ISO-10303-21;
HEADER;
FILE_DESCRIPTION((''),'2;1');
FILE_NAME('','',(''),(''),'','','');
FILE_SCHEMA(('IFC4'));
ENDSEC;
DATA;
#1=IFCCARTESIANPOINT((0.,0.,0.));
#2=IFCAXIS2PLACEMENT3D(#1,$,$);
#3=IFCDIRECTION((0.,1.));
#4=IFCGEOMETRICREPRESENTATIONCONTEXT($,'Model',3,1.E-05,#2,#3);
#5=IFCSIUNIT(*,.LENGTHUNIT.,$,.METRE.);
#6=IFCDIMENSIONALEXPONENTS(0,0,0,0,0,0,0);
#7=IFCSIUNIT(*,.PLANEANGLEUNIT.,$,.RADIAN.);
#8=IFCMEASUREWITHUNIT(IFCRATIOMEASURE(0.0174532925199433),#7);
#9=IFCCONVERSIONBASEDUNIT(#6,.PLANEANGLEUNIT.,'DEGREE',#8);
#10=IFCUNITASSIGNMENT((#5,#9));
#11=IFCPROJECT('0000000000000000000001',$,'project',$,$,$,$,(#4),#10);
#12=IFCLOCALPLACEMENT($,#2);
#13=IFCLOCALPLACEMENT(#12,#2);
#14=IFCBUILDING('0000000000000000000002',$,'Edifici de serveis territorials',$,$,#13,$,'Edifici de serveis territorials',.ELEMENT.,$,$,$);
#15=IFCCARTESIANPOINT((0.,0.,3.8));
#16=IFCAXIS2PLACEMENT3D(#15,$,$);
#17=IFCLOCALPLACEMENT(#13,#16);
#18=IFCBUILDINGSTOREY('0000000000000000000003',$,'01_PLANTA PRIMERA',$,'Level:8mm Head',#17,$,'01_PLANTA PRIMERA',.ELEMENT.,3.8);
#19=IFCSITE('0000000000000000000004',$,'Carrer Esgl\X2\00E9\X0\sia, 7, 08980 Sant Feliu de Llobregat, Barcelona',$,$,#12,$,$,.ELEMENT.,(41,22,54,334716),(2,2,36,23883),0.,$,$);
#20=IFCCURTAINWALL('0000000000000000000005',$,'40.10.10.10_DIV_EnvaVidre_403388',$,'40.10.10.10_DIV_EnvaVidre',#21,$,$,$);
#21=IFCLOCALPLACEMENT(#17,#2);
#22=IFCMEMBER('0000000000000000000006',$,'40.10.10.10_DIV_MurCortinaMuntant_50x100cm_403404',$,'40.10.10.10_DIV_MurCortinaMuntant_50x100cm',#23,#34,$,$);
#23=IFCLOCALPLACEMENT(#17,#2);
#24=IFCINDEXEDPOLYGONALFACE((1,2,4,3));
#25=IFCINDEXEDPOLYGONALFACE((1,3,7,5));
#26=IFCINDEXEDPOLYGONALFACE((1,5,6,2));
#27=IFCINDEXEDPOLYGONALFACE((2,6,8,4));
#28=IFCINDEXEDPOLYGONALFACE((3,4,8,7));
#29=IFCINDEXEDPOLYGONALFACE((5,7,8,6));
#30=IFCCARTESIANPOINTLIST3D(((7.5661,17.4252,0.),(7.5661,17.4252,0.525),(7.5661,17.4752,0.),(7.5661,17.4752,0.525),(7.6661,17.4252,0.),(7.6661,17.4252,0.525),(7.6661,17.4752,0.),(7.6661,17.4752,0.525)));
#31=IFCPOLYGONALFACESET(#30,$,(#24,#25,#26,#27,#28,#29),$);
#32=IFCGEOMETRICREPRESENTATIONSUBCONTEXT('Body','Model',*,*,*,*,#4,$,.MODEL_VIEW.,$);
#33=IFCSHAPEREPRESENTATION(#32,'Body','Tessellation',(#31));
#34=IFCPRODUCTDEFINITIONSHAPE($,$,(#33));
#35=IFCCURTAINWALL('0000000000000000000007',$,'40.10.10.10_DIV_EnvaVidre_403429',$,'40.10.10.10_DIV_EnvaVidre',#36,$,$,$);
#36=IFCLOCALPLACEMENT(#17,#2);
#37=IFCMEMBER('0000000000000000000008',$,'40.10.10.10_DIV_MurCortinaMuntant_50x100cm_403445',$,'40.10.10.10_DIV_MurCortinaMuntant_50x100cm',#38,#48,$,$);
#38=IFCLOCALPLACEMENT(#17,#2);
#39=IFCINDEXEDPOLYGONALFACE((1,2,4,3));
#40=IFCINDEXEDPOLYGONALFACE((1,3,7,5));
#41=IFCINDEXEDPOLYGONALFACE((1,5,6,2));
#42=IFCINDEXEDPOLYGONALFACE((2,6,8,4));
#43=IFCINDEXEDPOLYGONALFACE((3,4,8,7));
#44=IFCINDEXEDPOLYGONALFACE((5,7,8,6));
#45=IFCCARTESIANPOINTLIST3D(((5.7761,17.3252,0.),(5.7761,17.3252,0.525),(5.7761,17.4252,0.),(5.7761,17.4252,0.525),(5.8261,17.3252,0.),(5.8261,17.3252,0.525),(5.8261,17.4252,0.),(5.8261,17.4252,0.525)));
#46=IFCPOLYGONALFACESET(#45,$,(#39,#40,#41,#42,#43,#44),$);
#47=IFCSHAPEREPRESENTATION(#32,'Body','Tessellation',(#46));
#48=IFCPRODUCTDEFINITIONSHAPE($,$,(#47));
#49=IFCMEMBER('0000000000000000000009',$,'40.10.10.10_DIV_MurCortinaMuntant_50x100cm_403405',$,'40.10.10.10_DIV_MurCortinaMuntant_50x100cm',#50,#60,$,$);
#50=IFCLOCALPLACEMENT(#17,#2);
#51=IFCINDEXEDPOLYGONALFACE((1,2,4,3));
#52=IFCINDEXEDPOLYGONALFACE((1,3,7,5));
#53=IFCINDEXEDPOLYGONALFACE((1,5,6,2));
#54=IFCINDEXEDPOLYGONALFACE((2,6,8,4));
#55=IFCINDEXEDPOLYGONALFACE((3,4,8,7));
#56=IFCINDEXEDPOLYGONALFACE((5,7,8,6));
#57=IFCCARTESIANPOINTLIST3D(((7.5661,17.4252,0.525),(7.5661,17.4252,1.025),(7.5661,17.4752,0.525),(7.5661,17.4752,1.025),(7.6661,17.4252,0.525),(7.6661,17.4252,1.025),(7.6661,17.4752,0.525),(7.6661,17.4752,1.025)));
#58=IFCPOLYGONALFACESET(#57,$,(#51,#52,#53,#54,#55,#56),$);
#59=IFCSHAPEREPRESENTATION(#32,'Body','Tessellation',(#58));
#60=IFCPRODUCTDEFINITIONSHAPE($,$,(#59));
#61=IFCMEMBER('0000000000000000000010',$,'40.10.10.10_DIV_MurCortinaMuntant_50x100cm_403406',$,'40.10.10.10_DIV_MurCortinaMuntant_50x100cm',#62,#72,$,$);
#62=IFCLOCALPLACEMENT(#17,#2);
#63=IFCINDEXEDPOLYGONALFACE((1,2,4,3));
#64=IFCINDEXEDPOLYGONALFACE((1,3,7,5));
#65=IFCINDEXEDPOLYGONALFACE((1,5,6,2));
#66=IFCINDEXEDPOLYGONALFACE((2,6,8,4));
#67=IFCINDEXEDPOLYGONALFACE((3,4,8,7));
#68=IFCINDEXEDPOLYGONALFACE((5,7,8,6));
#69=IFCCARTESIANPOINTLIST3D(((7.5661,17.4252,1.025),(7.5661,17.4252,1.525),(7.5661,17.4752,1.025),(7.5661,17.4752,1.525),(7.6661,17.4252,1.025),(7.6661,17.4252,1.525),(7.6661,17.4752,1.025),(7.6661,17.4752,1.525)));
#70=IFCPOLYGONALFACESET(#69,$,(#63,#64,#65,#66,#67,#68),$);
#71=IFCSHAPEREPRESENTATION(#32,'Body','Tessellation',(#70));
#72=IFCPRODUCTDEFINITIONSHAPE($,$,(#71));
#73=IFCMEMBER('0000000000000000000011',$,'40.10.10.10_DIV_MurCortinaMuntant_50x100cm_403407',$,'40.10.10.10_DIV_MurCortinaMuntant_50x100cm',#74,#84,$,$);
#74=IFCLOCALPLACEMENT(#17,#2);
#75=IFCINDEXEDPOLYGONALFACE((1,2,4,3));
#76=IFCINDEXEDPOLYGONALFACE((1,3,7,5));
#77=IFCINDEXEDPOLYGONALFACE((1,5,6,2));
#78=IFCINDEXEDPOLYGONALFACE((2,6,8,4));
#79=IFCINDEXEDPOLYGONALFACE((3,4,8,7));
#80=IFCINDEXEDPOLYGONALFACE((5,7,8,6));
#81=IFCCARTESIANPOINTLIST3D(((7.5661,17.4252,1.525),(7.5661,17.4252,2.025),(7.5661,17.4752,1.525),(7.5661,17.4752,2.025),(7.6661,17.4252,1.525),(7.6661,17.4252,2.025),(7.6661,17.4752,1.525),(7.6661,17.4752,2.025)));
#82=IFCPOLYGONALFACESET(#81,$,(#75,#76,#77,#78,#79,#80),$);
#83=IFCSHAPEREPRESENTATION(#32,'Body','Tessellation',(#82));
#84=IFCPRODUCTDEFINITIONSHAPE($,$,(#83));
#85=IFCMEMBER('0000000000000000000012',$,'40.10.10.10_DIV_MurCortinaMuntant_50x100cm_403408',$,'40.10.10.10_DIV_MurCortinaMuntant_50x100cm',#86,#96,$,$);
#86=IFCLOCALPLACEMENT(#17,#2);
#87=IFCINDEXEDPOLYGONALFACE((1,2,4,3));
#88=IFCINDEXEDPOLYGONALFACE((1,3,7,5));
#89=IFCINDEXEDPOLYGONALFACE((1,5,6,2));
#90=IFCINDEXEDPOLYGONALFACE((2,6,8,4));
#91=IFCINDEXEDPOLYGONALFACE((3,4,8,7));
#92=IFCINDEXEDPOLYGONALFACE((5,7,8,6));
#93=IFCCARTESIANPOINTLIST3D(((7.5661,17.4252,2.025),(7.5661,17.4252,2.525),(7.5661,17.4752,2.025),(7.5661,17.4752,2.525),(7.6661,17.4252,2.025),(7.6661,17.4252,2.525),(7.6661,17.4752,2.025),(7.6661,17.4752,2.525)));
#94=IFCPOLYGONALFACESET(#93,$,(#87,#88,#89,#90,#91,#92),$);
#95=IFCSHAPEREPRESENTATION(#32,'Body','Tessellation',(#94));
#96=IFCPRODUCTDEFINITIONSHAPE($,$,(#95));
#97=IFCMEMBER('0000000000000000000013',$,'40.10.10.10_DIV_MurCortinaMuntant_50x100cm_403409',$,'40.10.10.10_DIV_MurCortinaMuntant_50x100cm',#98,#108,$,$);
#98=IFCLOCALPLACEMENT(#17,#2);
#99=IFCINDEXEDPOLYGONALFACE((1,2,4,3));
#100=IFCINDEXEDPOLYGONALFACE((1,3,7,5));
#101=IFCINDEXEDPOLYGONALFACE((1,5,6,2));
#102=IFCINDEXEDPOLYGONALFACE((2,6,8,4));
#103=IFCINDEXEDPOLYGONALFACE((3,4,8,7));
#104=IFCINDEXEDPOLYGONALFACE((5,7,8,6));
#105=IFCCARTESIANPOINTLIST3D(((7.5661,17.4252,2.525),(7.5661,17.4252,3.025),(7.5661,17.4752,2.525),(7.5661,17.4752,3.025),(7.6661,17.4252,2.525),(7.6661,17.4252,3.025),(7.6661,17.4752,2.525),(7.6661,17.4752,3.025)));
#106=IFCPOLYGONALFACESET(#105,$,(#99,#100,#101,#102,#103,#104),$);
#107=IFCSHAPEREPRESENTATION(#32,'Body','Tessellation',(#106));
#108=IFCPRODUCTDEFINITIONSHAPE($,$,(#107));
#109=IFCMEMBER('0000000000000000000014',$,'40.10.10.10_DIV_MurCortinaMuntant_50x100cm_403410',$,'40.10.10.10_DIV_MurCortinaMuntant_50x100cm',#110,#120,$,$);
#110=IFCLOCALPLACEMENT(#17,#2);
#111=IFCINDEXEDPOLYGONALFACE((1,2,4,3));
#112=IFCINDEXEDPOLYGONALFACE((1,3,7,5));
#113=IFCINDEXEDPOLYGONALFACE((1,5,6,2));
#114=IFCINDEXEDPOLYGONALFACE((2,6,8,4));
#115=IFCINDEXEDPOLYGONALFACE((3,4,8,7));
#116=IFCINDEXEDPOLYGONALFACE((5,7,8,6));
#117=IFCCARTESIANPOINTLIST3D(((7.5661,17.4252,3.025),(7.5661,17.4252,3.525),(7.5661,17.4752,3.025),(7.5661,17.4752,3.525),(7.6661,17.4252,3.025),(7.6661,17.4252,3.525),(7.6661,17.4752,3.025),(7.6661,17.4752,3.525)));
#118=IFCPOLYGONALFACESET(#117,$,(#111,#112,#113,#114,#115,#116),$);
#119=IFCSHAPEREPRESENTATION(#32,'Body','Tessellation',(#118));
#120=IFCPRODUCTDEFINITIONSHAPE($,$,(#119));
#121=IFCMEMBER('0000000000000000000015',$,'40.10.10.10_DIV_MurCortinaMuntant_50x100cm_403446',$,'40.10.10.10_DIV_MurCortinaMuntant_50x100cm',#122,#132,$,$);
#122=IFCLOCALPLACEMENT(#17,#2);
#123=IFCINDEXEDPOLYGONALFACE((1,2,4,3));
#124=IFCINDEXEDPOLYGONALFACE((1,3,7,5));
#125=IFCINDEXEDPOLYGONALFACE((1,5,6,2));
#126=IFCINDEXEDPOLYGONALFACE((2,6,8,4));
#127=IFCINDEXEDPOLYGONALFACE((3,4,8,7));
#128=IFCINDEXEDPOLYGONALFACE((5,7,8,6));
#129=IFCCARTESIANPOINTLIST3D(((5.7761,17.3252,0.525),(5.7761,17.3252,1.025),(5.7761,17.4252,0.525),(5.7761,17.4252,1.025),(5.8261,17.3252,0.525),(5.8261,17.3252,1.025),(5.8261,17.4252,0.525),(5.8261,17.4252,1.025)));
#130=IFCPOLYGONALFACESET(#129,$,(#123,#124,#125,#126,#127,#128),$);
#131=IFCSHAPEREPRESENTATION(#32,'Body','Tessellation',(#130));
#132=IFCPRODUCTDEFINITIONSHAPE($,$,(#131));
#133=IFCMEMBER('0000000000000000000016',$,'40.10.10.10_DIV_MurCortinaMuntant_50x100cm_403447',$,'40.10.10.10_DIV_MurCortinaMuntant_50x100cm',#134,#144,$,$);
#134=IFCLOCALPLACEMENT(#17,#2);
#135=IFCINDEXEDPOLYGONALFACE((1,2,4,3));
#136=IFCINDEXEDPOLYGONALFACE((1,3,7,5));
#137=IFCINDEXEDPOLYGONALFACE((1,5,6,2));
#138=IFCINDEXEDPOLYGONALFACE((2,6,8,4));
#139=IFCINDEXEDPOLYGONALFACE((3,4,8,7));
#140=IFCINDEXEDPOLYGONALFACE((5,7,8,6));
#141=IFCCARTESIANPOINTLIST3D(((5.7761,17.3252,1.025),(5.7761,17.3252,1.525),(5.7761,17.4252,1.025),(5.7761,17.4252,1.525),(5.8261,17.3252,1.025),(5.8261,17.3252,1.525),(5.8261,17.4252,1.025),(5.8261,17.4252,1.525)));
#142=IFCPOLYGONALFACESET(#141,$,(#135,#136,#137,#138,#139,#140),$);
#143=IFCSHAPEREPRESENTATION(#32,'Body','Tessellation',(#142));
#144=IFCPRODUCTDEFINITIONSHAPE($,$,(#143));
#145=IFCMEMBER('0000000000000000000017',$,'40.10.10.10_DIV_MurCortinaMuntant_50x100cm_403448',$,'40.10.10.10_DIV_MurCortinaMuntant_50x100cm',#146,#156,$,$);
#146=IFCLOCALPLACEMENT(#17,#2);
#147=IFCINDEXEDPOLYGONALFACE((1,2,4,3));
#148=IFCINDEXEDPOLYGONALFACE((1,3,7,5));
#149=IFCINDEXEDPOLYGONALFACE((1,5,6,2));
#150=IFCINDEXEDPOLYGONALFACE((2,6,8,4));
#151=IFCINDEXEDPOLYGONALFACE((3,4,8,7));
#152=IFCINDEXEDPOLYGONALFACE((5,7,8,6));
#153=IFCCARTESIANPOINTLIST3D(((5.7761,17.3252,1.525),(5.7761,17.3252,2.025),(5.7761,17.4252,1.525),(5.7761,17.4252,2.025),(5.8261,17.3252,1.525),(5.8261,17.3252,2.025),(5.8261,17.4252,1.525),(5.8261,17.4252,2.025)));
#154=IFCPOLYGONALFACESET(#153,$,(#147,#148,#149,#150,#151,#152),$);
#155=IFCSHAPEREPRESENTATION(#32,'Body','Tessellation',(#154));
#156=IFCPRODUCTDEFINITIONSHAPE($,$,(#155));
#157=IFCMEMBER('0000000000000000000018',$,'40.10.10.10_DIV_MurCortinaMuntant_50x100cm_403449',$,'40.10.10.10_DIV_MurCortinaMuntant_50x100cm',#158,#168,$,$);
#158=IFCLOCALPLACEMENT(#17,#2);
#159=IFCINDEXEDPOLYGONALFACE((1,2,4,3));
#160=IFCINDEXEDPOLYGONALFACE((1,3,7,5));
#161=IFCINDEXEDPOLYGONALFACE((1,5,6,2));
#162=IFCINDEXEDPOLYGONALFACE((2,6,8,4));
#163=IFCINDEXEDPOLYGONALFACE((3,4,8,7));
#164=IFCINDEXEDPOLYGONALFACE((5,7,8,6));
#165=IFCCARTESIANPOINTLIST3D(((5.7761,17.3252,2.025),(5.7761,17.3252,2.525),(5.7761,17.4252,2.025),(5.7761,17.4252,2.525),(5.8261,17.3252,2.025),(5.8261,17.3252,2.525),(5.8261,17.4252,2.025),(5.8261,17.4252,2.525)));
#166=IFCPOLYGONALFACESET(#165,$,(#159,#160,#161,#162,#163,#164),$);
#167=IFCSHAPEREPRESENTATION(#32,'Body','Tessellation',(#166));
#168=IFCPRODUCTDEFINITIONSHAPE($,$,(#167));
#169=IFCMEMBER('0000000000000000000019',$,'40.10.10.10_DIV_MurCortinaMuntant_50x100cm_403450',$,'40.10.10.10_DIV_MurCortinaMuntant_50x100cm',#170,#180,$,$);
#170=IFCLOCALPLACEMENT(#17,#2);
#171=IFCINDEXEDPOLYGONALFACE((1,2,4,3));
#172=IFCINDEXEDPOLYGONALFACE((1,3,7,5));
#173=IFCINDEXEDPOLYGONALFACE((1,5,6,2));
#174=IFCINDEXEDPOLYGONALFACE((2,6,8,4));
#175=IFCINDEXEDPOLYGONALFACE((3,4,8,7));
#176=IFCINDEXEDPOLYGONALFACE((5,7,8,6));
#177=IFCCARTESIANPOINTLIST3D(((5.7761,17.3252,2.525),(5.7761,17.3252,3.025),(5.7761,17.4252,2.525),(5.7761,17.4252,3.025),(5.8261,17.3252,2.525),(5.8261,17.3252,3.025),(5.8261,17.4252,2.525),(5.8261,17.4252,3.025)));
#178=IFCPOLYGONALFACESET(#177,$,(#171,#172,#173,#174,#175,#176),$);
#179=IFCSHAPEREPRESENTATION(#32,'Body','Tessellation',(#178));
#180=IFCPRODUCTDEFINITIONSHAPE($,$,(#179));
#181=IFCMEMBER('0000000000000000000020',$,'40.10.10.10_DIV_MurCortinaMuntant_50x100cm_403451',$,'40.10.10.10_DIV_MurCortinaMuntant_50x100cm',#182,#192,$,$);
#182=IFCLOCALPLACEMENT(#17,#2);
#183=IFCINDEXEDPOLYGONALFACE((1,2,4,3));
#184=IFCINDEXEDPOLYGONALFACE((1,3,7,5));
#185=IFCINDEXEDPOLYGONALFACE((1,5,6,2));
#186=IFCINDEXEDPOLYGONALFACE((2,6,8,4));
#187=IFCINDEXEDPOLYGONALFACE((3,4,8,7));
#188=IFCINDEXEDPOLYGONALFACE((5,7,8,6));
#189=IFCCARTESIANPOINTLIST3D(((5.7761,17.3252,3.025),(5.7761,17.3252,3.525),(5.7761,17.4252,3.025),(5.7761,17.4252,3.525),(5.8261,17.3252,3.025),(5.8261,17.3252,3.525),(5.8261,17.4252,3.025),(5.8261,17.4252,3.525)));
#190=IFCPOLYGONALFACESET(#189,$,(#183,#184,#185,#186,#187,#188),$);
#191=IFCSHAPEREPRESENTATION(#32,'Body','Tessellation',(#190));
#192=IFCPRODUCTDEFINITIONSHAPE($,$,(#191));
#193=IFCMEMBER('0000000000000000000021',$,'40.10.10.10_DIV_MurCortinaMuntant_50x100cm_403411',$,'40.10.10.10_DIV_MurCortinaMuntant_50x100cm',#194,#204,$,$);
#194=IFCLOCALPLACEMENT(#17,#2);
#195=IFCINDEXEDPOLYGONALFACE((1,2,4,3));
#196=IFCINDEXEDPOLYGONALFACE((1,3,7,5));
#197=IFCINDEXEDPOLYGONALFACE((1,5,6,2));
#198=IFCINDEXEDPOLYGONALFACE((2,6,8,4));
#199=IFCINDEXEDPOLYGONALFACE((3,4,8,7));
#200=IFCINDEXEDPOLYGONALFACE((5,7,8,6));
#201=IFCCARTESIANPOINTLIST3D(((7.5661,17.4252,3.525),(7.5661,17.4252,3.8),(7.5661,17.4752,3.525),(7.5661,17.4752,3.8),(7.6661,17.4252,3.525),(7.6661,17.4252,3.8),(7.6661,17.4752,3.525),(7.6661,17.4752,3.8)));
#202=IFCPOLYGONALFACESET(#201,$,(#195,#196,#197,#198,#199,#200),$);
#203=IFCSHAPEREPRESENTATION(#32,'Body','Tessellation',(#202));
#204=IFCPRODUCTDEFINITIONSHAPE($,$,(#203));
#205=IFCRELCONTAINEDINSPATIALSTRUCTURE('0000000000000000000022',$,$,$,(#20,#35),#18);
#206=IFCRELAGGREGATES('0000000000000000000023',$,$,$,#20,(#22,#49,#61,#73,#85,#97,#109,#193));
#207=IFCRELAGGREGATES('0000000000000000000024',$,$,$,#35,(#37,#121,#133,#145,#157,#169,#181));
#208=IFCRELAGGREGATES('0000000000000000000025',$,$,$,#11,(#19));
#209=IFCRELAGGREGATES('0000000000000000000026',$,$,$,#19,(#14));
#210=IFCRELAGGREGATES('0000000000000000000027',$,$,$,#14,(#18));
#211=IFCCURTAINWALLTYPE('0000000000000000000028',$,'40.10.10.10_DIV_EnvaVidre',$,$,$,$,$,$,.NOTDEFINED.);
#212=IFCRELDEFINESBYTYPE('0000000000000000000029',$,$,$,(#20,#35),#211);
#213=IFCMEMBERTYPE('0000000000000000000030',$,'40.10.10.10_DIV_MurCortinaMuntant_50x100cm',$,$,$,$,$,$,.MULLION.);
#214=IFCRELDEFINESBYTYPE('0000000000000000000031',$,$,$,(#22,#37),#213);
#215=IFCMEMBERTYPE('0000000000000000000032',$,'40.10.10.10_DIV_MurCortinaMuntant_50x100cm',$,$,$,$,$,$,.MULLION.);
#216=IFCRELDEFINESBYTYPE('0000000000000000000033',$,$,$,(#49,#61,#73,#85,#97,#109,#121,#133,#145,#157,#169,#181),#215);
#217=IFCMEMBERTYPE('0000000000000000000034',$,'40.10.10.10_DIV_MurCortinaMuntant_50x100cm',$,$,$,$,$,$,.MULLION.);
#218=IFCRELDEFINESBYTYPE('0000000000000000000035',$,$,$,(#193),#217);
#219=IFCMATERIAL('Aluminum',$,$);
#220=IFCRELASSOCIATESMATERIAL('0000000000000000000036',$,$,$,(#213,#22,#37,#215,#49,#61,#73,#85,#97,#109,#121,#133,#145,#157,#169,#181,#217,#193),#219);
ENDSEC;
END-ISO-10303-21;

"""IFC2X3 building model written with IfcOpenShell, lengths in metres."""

from ifc_helpers import new_model, entity, si_unit, converted_unit, direction, frame, origin, origin_2d_with_axis, place, context, subcontext, project, spatial, rectangle, extrude, source, transform, mapped, material, type_object, type_shapes, element, aggregate, save


model = new_model("IFC2X3")

# Units and contexts
model_context = context("Model", 3, precision=1e-05, world=origin(), true_north=direction((0.0, 1.0)))
body_context = subcontext(model_context, "Body", "Model", "MODEL_VIEW")
ifc_project = project(units=[si_unit("LENGTHUNIT", "METRE"), converted_unit("PLANEANGLEUNIT", "DEGREE", entity("IfcRatioMeasure", 0.0174532925199433), si_unit("PLANEANGLEUNIT", "RADIAN"), dimensions=[0, 0, 0, 0, 0, 0, 0])], contexts=[model_context])

# Site, building, storey
site_placement = place(None, origin())
site = spatial("IfcSite", under=ifc_project, at=site_placement, Name="Carrer Església, 7, 08980 Sant Feliu de Llobregat, Barcelona", CompositionType="ELEMENT", RefLatitude=(41, 22, 54, 334716), RefLongitude=(2, 2, 36, 23883), RefElevation=0.0)
building_placement = place(site_placement, origin())
building = spatial("IfcBuilding", under=site, at=building_placement, Name="Edifici de serveis territorials", LongName="Edifici de serveis territorials", CompositionType="ELEMENT")
storey_placement = place(building_placement, frame((0.0, 0.0, 3.8)))
storey = spatial("IfcBuildingStorey", under=building, at=storey_placement, Name="01_PLANTA PRIMERA", ObjectType="Level:8mm Head", LongName="01_PLANTA PRIMERA", CompositionType="ELEMENT", Elevation=3.8)

# Curtain walls, members
curtain_wall_type = type_object("IfcCurtainWallType", Name="40.10.10.10_DIV_EnvaVidre", PredefinedType="NOTDEFINED")
curtain_wall_1_placement = place(storey_placement, frame((0.0, 0.0, -3.8)))
curtain_wall_1 = element("IfcCurtainWall", 1, at=curtain_wall_1_placement, inside=storey, type_object=curtain_wall_type, Name="40.10.10.10_DIV_EnvaVidre_403388", ObjectType="40.10.10.10_DIV_EnvaVidre")
ifc_material_1 = material(Name="Aluminum")
member_type_1 = type_object("IfcMemberType", Name="40.10.10.10_DIV_MurCortinaMuntant_50x100cm", PredefinedType="MULLION", material=ifc_material_1)
shared_shape_1 = source(origin(), body_context, "Body", "SweptSolid", [
    extrude(rectangle(XDim=0.1, YDim=0.05, at=origin_2d_with_axis()), frame((-0.025, 0.0, -0.525), z_axis=(0.0, 0.0, 1.0), x_axis=(0.0, -1.0, 0.0)), (0.0, 0.0, 1.0), 0.525),
])
type_shapes(member_type_1, [shared_shape_1])
member_1_placement = place(storey_placement, frame((7.6161, 17.4252, 0.0), z_axis=(0.0, 0.0, -1.0), x_axis=(0.0, -1.0, 0.0)))
member_1 = element("IfcMember", 2, at=member_1_placement, type_object=member_type_1, material=ifc_material_1, Name="40.10.10.10_DIV_MurCortinaMuntant_50x100cm_403404", ObjectType="40.10.10.10_DIV_MurCortinaMuntant_50x100cm", context=body_context, shape_type="MappedRepresentation", body=[
    mapped(shared_shape_1, transform((0.0, 0.0, 0.0), scale=1.0)),
])
curtain_wall_2_placement = place(storey_placement, frame((0.0, 0.0, -3.8)))
curtain_wall_2 = element("IfcCurtainWall", 3, at=curtain_wall_2_placement, inside=storey, type_object=curtain_wall_type, Name="40.10.10.10_DIV_EnvaVidre_403429", ObjectType="40.10.10.10_DIV_EnvaVidre")
member_2_placement = place(storey_placement, frame((5.7761, 17.3752, 0.0), z_axis=(0.0, 0.0, -1.0), x_axis=(-1.0, 0.0, 0.0)))
member_2 = element("IfcMember", 4, at=member_2_placement, type_object=member_type_1, material=ifc_material_1, Name="40.10.10.10_DIV_MurCortinaMuntant_50x100cm_403445", ObjectType="40.10.10.10_DIV_MurCortinaMuntant_50x100cm", context=body_context, shape_type="MappedRepresentation", body=[
    mapped(shared_shape_1, transform((0.0, 0.0, 0.0), scale=1.0)),
])

# Members
member_type_2 = type_object("IfcMemberType", Name="40.10.10.10_DIV_MurCortinaMuntant_50x100cm", PredefinedType="MULLION", material=ifc_material_1)
shared_shape_2 = source(origin(), body_context, "Body", "SweptSolid", [
    extrude(rectangle(XDim=0.1, YDim=0.05, at=origin_2d_with_axis()), frame((-0.025, 0.0, -0.5), z_axis=(0.0, 0.0, 1.0), x_axis=(0.0, -1.0, 0.0)), (0.0, 0.0, 1.0), 0.5),
])
type_shapes(member_type_2, [shared_shape_2])
member_3_placement = place(storey_placement, frame((7.6161, 17.4252, 0.525), z_axis=(0.0, 0.0, -1.0), x_axis=(0.0, -1.0, 0.0)))
member_3 = element("IfcMember", 5, at=member_3_placement, type_object=member_type_2, material=ifc_material_1, Name="40.10.10.10_DIV_MurCortinaMuntant_50x100cm_403405", ObjectType="40.10.10.10_DIV_MurCortinaMuntant_50x100cm", context=body_context, shape_type="MappedRepresentation", body=[
    mapped(shared_shape_2, transform((0.0, 0.0, 0.0), scale=1.0)),
])
member_4_placement = place(storey_placement, frame((7.6161, 17.4252, 1.025), z_axis=(0.0, 0.0, -1.0), x_axis=(0.0, -1.0, 0.0)))
member_4 = element("IfcMember", 6, at=member_4_placement, type_object=member_type_2, material=ifc_material_1, Name="40.10.10.10_DIV_MurCortinaMuntant_50x100cm_403406", ObjectType="40.10.10.10_DIV_MurCortinaMuntant_50x100cm", context=body_context, shape_type="MappedRepresentation", body=[
    mapped(shared_shape_2, transform((0.0, 0.0, 0.0), scale=1.0)),
])
member_5_placement = place(storey_placement, frame((7.6161, 17.4252, 1.525), z_axis=(0.0, 0.0, -1.0), x_axis=(0.0, -1.0, 0.0)))
member_5 = element("IfcMember", 7, at=member_5_placement, type_object=member_type_2, material=ifc_material_1, Name="40.10.10.10_DIV_MurCortinaMuntant_50x100cm_403407", ObjectType="40.10.10.10_DIV_MurCortinaMuntant_50x100cm", context=body_context, shape_type="MappedRepresentation", body=[
    mapped(shared_shape_2, transform((0.0, 0.0, 0.0), scale=1.0)),
])
member_6_placement = place(storey_placement, frame((7.6161, 17.4252, 2.025), z_axis=(0.0, 0.0, -1.0), x_axis=(0.0, -1.0, 0.0)))
member_6 = element("IfcMember", 8, at=member_6_placement, type_object=member_type_2, material=ifc_material_1, Name="40.10.10.10_DIV_MurCortinaMuntant_50x100cm_403408", ObjectType="40.10.10.10_DIV_MurCortinaMuntant_50x100cm", context=body_context, shape_type="MappedRepresentation", body=[
    mapped(shared_shape_2, transform((0.0, 0.0, 0.0), scale=1.0)),
])
member_7_placement = place(storey_placement, frame((7.6161, 17.4252, 2.525), z_axis=(0.0, 0.0, -1.0), x_axis=(0.0, -1.0, 0.0)))
member_7 = element("IfcMember", 9, at=member_7_placement, type_object=member_type_2, material=ifc_material_1, Name="40.10.10.10_DIV_MurCortinaMuntant_50x100cm_403409", ObjectType="40.10.10.10_DIV_MurCortinaMuntant_50x100cm", context=body_context, shape_type="MappedRepresentation", body=[
    mapped(shared_shape_2, transform((0.0, 0.0, 0.0), scale=1.0)),
])
member_8_placement = place(storey_placement, frame((7.6161, 17.4252, 3.025), z_axis=(0.0, 0.0, -1.0), x_axis=(0.0, -1.0, 0.0)))
member_8 = element("IfcMember", 10, at=member_8_placement, type_object=member_type_2, material=ifc_material_1, Name="40.10.10.10_DIV_MurCortinaMuntant_50x100cm_403410", ObjectType="40.10.10.10_DIV_MurCortinaMuntant_50x100cm", context=body_context, shape_type="MappedRepresentation", body=[
    mapped(shared_shape_2, transform((0.0, 0.0, 0.0), scale=1.0)),
])
member_9_placement = place(storey_placement, frame((5.7761, 17.3752, 0.525), z_axis=(0.0, 0.0, -1.0), x_axis=(-1.0, 0.0, 0.0)))
member_9 = element("IfcMember", 11, at=member_9_placement, type_object=member_type_2, material=ifc_material_1, Name="40.10.10.10_DIV_MurCortinaMuntant_50x100cm_403446", ObjectType="40.10.10.10_DIV_MurCortinaMuntant_50x100cm", context=body_context, shape_type="MappedRepresentation", body=[
    mapped(shared_shape_2, transform((0.0, 0.0, 0.0), scale=1.0)),
])
member_10_placement = place(storey_placement, frame((5.7761, 17.3752, 1.025), z_axis=(0.0, 0.0, -1.0), x_axis=(-1.0, 0.0, 0.0)))
member_10 = element("IfcMember", 12, at=member_10_placement, type_object=member_type_2, material=ifc_material_1, Name="40.10.10.10_DIV_MurCortinaMuntant_50x100cm_403447", ObjectType="40.10.10.10_DIV_MurCortinaMuntant_50x100cm", context=body_context, shape_type="MappedRepresentation", body=[
    mapped(shared_shape_2, transform((0.0, 0.0, 0.0), scale=1.0)),
])
member_11_placement = place(storey_placement, frame((5.7761, 17.3752, 1.525), z_axis=(0.0, 0.0, -1.0), x_axis=(-1.0, 0.0, 0.0)))
member_11 = element("IfcMember", 13, at=member_11_placement, type_object=member_type_2, material=ifc_material_1, Name="40.10.10.10_DIV_MurCortinaMuntant_50x100cm_403448", ObjectType="40.10.10.10_DIV_MurCortinaMuntant_50x100cm", context=body_context, shape_type="MappedRepresentation", body=[
    mapped(shared_shape_2, transform((0.0, 0.0, 0.0), scale=1.0)),
])
member_12_placement = place(storey_placement, frame((5.7761, 17.3752, 2.025), z_axis=(0.0, 0.0, -1.0), x_axis=(-1.0, 0.0, 0.0)))
member_12 = element("IfcMember", 14, at=member_12_placement, type_object=member_type_2, material=ifc_material_1, Name="40.10.10.10_DIV_MurCortinaMuntant_50x100cm_403449", ObjectType="40.10.10.10_DIV_MurCortinaMuntant_50x100cm", context=body_context, shape_type="MappedRepresentation", body=[
    mapped(shared_shape_2, transform((0.0, 0.0, 0.0), scale=1.0)),
])
member_13_placement = place(storey_placement, frame((5.7761, 17.3752, 2.525), z_axis=(0.0, 0.0, -1.0), x_axis=(-1.0, 0.0, 0.0)))
member_13 = element("IfcMember", 15, at=member_13_placement, type_object=member_type_2, material=ifc_material_1, Name="40.10.10.10_DIV_MurCortinaMuntant_50x100cm_403450", ObjectType="40.10.10.10_DIV_MurCortinaMuntant_50x100cm", context=body_context, shape_type="MappedRepresentation", body=[
    mapped(shared_shape_2, transform((0.0, 0.0, 0.0), scale=1.0)),
])
member_14_placement = place(storey_placement, frame((5.7761, 17.3752, 3.025), z_axis=(0.0, 0.0, -1.0), x_axis=(-1.0, 0.0, 0.0)))
member_14 = element("IfcMember", 16, at=member_14_placement, type_object=member_type_2, material=ifc_material_1, Name="40.10.10.10_DIV_MurCortinaMuntant_50x100cm_403451", ObjectType="40.10.10.10_DIV_MurCortinaMuntant_50x100cm", context=body_context, shape_type="MappedRepresentation", body=[
    mapped(shared_shape_2, transform((0.0, 0.0, 0.0), scale=1.0)),
])
member_type_3 = type_object("IfcMemberType", Name="40.10.10.10_DIV_MurCortinaMuntant_50x100cm", PredefinedType="MULLION", material=ifc_material_1)
shared_shape_3 = source(origin(), body_context, "Body", "SweptSolid", [
    extrude(rectangle(XDim=0.1, YDim=0.05, at=origin_2d_with_axis()), frame((-0.025, 0.0, -0.275), z_axis=(0.0, 0.0, 1.0), x_axis=(0.0, -1.0, 0.0)), (0.0, 0.0, 1.0), 0.275),
])
type_shapes(member_type_3, [shared_shape_3])
member_15_placement = place(storey_placement, frame((7.6161, 17.4252, 3.525), z_axis=(0.0, 0.0, -1.0), x_axis=(0.0, -1.0, 0.0)))
member_15 = element("IfcMember", 17, at=member_15_placement, type_object=member_type_3, material=ifc_material_1, Name="40.10.10.10_DIV_MurCortinaMuntant_50x100cm_403411", ObjectType="40.10.10.10_DIV_MurCortinaMuntant_50x100cm", context=body_context, shape_type="MappedRepresentation", body=[
    mapped(shared_shape_3, transform((0.0, 0.0, 0.0), scale=1.0)),
])
aggregate(curtain_wall_1, [member_1, member_3, member_4, member_5, member_6, member_7, member_8, member_15])

aggregate(curtain_wall_2, [member_2, member_9, member_10, member_11, member_12, member_13, member_14])

save(model, "model.ifc")
